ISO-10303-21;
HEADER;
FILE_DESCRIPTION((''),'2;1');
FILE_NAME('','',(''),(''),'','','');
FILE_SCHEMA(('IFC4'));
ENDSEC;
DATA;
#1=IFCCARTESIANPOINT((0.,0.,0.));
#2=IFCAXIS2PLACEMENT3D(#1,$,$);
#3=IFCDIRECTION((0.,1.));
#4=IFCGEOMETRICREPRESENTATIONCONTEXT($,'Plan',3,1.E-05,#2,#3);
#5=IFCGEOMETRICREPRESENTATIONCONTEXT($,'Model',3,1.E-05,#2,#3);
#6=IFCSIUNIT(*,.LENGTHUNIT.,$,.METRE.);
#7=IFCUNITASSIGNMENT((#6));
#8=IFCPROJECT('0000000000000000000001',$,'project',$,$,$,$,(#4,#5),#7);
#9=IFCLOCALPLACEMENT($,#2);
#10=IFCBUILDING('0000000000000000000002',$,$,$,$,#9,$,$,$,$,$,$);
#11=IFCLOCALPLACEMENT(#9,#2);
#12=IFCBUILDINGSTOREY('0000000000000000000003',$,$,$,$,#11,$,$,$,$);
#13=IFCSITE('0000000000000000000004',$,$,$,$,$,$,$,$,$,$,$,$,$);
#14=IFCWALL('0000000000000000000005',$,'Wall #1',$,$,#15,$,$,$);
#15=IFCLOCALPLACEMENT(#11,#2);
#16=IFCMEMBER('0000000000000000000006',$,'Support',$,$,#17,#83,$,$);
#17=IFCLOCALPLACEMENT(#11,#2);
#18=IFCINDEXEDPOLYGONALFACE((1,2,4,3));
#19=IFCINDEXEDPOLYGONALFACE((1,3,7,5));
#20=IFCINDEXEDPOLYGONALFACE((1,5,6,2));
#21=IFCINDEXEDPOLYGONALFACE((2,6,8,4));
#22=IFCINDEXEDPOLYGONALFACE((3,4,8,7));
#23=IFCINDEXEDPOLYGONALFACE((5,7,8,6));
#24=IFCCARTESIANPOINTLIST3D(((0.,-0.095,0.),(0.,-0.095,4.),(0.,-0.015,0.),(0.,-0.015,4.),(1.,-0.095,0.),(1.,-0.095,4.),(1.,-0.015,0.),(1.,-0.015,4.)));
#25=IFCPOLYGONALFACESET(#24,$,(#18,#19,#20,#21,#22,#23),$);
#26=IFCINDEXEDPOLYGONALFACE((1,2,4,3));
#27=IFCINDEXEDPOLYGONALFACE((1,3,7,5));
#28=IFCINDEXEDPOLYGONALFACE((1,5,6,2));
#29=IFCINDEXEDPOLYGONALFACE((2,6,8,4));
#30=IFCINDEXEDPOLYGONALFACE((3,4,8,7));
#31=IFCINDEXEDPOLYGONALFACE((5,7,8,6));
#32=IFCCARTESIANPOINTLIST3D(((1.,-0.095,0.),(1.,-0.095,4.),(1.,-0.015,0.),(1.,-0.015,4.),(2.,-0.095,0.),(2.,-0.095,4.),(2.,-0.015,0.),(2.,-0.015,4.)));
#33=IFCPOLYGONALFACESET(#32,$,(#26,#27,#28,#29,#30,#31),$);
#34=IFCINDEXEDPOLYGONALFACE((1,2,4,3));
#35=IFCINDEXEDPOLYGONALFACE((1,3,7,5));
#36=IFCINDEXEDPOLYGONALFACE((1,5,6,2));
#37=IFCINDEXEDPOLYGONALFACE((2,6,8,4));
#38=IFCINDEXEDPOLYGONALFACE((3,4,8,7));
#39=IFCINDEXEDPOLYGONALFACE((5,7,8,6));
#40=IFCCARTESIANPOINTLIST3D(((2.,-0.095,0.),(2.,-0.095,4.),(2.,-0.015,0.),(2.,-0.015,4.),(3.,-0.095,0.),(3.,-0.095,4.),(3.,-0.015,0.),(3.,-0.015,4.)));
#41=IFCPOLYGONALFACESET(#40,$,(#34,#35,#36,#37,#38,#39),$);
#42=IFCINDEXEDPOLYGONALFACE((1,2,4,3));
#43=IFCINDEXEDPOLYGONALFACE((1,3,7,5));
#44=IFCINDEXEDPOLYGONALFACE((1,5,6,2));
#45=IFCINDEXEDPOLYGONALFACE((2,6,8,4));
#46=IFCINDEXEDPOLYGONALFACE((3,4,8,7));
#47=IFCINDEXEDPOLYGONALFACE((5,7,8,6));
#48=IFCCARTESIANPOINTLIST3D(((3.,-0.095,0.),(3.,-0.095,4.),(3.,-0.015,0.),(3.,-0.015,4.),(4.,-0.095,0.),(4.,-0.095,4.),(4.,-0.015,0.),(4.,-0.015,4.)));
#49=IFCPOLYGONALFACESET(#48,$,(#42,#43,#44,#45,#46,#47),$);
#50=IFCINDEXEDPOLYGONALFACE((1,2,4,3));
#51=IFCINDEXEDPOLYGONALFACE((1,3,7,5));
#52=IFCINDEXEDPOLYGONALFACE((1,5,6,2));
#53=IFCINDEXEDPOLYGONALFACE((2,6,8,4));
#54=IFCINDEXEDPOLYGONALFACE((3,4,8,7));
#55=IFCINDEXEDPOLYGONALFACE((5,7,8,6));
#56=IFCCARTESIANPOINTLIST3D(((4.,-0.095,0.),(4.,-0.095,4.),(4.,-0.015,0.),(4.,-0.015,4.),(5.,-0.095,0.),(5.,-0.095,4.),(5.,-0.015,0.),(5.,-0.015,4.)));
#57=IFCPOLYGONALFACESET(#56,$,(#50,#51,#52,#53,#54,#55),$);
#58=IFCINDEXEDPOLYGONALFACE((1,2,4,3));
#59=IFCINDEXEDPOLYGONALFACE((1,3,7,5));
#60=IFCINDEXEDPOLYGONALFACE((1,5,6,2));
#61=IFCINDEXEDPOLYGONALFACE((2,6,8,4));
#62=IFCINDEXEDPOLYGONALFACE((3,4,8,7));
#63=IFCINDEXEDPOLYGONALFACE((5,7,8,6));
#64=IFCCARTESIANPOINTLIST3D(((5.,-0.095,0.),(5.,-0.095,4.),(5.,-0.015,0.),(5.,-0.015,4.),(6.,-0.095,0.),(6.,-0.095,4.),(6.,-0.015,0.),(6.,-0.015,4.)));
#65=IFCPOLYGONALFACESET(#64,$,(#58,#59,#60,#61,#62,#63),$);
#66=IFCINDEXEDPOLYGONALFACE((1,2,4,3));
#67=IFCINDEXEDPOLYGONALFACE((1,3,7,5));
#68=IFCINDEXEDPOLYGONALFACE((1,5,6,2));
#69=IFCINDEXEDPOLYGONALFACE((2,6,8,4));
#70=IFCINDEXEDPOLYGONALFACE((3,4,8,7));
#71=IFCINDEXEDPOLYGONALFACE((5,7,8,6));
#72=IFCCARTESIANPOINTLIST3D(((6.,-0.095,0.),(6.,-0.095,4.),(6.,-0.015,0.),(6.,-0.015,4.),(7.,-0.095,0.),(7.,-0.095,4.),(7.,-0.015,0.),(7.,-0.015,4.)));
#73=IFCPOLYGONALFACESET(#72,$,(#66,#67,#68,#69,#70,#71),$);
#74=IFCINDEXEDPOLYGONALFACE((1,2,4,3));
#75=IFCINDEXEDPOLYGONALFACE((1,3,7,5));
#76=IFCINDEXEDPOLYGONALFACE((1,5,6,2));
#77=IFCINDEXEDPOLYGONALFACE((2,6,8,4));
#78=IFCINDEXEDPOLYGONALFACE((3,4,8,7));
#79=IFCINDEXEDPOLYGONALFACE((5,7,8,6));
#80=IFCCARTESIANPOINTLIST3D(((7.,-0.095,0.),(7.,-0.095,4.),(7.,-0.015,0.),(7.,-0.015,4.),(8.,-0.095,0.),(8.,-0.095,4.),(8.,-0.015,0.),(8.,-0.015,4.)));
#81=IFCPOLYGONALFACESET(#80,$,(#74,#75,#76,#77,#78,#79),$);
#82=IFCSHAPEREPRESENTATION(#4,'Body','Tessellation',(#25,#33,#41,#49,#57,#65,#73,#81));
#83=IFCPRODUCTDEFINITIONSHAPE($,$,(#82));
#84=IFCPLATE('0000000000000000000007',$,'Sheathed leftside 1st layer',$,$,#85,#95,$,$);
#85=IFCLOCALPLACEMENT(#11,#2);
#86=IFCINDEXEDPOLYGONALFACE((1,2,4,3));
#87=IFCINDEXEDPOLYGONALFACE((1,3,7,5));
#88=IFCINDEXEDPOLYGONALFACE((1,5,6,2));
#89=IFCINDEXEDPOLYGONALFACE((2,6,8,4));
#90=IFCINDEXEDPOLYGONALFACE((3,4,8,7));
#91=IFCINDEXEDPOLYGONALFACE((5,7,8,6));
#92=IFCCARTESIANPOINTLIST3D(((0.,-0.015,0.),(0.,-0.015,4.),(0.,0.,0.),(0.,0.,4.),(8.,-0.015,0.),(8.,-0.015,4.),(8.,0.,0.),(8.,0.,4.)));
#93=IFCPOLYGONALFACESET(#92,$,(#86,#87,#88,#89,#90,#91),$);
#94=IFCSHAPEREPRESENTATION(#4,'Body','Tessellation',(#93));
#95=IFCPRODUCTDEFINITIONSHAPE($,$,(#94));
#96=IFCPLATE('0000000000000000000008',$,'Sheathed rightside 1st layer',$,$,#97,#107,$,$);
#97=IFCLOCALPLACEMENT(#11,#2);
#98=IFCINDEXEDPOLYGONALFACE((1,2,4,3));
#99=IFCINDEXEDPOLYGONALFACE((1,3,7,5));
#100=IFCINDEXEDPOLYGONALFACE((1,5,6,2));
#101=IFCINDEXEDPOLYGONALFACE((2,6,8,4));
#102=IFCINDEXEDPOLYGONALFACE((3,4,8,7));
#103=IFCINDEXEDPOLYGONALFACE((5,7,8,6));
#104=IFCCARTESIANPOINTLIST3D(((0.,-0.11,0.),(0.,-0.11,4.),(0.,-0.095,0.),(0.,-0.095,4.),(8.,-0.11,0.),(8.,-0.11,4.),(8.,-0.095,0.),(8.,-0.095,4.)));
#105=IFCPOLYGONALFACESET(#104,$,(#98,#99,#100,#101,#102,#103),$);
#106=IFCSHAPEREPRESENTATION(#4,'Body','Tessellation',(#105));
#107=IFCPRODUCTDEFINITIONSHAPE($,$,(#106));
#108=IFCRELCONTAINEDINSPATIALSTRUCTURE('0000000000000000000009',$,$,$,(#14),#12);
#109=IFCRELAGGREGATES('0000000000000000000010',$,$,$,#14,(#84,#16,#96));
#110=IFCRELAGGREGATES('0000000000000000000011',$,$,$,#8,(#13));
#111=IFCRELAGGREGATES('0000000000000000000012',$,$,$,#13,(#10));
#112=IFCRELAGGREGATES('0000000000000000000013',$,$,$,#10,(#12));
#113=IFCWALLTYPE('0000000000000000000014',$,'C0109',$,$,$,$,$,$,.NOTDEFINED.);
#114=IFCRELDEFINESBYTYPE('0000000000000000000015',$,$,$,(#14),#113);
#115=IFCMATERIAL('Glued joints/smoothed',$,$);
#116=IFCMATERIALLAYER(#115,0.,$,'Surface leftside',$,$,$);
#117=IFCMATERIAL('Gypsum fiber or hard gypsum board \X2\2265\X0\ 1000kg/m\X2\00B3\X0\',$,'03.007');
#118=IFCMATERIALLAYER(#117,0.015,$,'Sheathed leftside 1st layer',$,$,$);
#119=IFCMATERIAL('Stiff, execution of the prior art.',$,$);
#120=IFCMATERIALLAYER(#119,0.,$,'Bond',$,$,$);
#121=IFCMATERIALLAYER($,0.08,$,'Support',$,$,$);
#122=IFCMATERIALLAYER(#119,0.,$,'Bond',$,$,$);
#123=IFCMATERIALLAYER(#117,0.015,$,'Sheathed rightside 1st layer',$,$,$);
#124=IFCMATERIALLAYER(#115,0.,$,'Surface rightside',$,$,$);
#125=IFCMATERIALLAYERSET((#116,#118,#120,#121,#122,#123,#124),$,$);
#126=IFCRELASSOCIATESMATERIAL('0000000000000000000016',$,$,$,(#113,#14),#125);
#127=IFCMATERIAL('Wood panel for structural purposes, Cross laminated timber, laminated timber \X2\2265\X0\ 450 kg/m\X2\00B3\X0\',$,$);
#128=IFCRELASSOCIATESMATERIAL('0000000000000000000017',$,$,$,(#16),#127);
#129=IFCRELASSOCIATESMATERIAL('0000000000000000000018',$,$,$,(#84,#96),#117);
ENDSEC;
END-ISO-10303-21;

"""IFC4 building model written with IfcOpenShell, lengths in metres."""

from ifc_helpers import new_model, si_unit, direction, frame, frame_2d, origin, origin_with_axes, place, context, project, spatial, rectangle, extrude, material, layer, layer_set, type_object, element, aggregate, save


model = new_model("IFC4")

# Units and contexts
plan_context = context("Plan", 3, precision=1e-05, world=origin(), true_north=direction((0.0, 1.0)))
model_context = context("Model", 3, precision=1e-05, world=origin(), true_north=direction((0.0, 1.0)))
ifc_project = project(units=[si_unit("LENGTHUNIT", "METRE")], contexts=[plan_context, model_context])

# Site, building, storey
site = spatial("IfcSite", under=ifc_project)
building_placement = place(None, origin())
building = spatial("IfcBuilding", under=site, at=building_placement)
storey_placement = place(building_placement, origin())
storey = spatial("IfcBuildingStorey", under=building, at=storey_placement)

# Wall, member, plates
ifc_material_1 = material(Name="Glued joints/smoothed")
ifc_layer_1 = layer(ifc_material_1, 0.0, Name="Surface leftside")
ifc_material_2 = material(Name="Gypsum fiber or hard gypsum board ≥ 1000kg/m³", Category="03.007")
ifc_layer_2 = layer(ifc_material_2, 0.015, Name="Sheathed leftside 1st layer")
ifc_material_3 = material(Name="Stiff, execution of the prior art.")
ifc_layer_3 = layer(ifc_material_3, 0.0, Name="Bond")
ifc_layer_4 = layer(None, 0.08, Name="Support")
ifc_layer_5 = layer(ifc_material_3, 0.0, Name="Bond")
ifc_layer_6 = layer(ifc_material_2, 0.015, Name="Sheathed rightside 1st layer")
ifc_layer_7 = layer(ifc_material_1, 0.0, Name="Surface rightside")
ifc_layer_set = layer_set([ifc_layer_1, ifc_layer_2, ifc_layer_3, ifc_layer_4, ifc_layer_5, ifc_layer_6, ifc_layer_7])
wall_type = type_object("IfcWallType", Name="C0109", PredefinedType="NOTDEFINED", material=ifc_layer_set)
wall_placement = place(None, frame((0.0, 0.0, 0.0), z_axis=(0.0, -1.0, 0.0), x_axis=(1.0, 0.0, 0.0)))
wall = element("IfcWall", 1, at=wall_placement, inside=storey, type_object=wall_type, material=ifc_layer_set, Name="Wall #1")
ifc_material_4 = material(Name="Wood panel for structural purposes, Cross laminated timber, laminated timber ≥ 450 kg/m³")
member_placement = place(wall_placement, origin())
member = element("IfcMember", 2, at=member_placement, material=ifc_material_4, Name="Support", context=plan_context, shape_type="SweptSolid", body=[
    extrude(rectangle(XDim=1.0, YDim=0.08, at=frame_2d((0.5, 0.04), x_axis=(1.0, 0.0))), frame((0.0, 4.0, 0.015), z_axis=(0.0, -1.0, 0.0), x_axis=(1.0, 0.0, 0.0)), (0.0, 0.0, 1.0), 4.0),
    extrude(rectangle(XDim=1.0, YDim=0.08, at=frame_2d((0.5, 0.04), x_axis=(1.0, 0.0))), frame((1.0, 4.0, 0.015), z_axis=(0.0, -1.0, 0.0), x_axis=(1.0, 0.0, 0.0)), (0.0, 0.0, 1.0), 4.0),
    extrude(rectangle(XDim=1.0, YDim=0.08, at=frame_2d((0.5, 0.04), x_axis=(1.0, 0.0))), frame((2.0, 4.0, 0.015), z_axis=(0.0, -1.0, 0.0), x_axis=(1.0, 0.0, 0.0)), (0.0, 0.0, 1.0), 4.0),
    extrude(rectangle(XDim=1.0, YDim=0.08, at=frame_2d((0.5, 0.04), x_axis=(1.0, 0.0))), frame((3.0, 4.0, 0.015), z_axis=(0.0, -1.0, 0.0), x_axis=(1.0, 0.0, 0.0)), (0.0, 0.0, 1.0), 4.0),
    extrude(rectangle(XDim=1.0, YDim=0.08, at=frame_2d((0.5, 0.04), x_axis=(1.0, 0.0))), frame((4.0, 4.0, 0.015), z_axis=(0.0, -1.0, 0.0), x_axis=(1.0, 0.0, 0.0)), (0.0, 0.0, 1.0), 4.0),
    extrude(rectangle(XDim=1.0, YDim=0.08, at=frame_2d((0.5, 0.04), x_axis=(1.0, 0.0))), frame((5.0, 4.0, 0.015), z_axis=(0.0, -1.0, 0.0), x_axis=(1.0, 0.0, 0.0)), (0.0, 0.0, 1.0), 4.0),
    extrude(rectangle(XDim=1.0, YDim=0.08, at=frame_2d((0.5, 0.04), x_axis=(1.0, 0.0))), frame((6.0, 4.0, 0.015), z_axis=(0.0, -1.0, 0.0), x_axis=(1.0, 0.0, 0.0)), (0.0, 0.0, 1.0), 4.0),
    extrude(rectangle(XDim=1.0, YDim=0.08, at=frame_2d((0.5, 0.04), x_axis=(1.0, 0.0))), frame((7.0, 4.0, 0.015), z_axis=(0.0, -1.0, 0.0), x_axis=(1.0, 0.0, 0.0)), (0.0, 0.0, 1.0), 4.0),
])
plate_1_placement = place(wall_placement, origin())
plate_1 = element("IfcPlate", 3, at=plate_1_placement, material=ifc_material_2, Name="Sheathed leftside 1st layer", context=plan_context, shape_type="SweptSolid", body=[
    extrude(rectangle(XDim=8.0, YDim=4.0, at=frame_2d((4.0, 2.0), x_axis=(1.0, 0.0))), origin_with_axes(), (0.0, 0.0, 1.0), 0.015),
])
plate_2_placement = place(wall_placement, origin())
plate_2 = element("IfcPlate", 4, at=plate_2_placement, material=ifc_material_2, Name="Sheathed rightside 1st layer", context=plan_context, shape_type="SweptSolid", body=[
    extrude(rectangle(XDim=8.0, YDim=4.0, at=frame_2d((4.0, 2.0), x_axis=(1.0, 0.0))), frame((0.0, 0.0, 0.095), z_axis=(0.0, 0.0, 1.0), x_axis=(1.0, 0.0, 0.0)), (0.0, 0.0, 1.0), 0.015),
])
aggregate(wall, [plate_1, member, plate_2])

save(model, "model.ifc")
